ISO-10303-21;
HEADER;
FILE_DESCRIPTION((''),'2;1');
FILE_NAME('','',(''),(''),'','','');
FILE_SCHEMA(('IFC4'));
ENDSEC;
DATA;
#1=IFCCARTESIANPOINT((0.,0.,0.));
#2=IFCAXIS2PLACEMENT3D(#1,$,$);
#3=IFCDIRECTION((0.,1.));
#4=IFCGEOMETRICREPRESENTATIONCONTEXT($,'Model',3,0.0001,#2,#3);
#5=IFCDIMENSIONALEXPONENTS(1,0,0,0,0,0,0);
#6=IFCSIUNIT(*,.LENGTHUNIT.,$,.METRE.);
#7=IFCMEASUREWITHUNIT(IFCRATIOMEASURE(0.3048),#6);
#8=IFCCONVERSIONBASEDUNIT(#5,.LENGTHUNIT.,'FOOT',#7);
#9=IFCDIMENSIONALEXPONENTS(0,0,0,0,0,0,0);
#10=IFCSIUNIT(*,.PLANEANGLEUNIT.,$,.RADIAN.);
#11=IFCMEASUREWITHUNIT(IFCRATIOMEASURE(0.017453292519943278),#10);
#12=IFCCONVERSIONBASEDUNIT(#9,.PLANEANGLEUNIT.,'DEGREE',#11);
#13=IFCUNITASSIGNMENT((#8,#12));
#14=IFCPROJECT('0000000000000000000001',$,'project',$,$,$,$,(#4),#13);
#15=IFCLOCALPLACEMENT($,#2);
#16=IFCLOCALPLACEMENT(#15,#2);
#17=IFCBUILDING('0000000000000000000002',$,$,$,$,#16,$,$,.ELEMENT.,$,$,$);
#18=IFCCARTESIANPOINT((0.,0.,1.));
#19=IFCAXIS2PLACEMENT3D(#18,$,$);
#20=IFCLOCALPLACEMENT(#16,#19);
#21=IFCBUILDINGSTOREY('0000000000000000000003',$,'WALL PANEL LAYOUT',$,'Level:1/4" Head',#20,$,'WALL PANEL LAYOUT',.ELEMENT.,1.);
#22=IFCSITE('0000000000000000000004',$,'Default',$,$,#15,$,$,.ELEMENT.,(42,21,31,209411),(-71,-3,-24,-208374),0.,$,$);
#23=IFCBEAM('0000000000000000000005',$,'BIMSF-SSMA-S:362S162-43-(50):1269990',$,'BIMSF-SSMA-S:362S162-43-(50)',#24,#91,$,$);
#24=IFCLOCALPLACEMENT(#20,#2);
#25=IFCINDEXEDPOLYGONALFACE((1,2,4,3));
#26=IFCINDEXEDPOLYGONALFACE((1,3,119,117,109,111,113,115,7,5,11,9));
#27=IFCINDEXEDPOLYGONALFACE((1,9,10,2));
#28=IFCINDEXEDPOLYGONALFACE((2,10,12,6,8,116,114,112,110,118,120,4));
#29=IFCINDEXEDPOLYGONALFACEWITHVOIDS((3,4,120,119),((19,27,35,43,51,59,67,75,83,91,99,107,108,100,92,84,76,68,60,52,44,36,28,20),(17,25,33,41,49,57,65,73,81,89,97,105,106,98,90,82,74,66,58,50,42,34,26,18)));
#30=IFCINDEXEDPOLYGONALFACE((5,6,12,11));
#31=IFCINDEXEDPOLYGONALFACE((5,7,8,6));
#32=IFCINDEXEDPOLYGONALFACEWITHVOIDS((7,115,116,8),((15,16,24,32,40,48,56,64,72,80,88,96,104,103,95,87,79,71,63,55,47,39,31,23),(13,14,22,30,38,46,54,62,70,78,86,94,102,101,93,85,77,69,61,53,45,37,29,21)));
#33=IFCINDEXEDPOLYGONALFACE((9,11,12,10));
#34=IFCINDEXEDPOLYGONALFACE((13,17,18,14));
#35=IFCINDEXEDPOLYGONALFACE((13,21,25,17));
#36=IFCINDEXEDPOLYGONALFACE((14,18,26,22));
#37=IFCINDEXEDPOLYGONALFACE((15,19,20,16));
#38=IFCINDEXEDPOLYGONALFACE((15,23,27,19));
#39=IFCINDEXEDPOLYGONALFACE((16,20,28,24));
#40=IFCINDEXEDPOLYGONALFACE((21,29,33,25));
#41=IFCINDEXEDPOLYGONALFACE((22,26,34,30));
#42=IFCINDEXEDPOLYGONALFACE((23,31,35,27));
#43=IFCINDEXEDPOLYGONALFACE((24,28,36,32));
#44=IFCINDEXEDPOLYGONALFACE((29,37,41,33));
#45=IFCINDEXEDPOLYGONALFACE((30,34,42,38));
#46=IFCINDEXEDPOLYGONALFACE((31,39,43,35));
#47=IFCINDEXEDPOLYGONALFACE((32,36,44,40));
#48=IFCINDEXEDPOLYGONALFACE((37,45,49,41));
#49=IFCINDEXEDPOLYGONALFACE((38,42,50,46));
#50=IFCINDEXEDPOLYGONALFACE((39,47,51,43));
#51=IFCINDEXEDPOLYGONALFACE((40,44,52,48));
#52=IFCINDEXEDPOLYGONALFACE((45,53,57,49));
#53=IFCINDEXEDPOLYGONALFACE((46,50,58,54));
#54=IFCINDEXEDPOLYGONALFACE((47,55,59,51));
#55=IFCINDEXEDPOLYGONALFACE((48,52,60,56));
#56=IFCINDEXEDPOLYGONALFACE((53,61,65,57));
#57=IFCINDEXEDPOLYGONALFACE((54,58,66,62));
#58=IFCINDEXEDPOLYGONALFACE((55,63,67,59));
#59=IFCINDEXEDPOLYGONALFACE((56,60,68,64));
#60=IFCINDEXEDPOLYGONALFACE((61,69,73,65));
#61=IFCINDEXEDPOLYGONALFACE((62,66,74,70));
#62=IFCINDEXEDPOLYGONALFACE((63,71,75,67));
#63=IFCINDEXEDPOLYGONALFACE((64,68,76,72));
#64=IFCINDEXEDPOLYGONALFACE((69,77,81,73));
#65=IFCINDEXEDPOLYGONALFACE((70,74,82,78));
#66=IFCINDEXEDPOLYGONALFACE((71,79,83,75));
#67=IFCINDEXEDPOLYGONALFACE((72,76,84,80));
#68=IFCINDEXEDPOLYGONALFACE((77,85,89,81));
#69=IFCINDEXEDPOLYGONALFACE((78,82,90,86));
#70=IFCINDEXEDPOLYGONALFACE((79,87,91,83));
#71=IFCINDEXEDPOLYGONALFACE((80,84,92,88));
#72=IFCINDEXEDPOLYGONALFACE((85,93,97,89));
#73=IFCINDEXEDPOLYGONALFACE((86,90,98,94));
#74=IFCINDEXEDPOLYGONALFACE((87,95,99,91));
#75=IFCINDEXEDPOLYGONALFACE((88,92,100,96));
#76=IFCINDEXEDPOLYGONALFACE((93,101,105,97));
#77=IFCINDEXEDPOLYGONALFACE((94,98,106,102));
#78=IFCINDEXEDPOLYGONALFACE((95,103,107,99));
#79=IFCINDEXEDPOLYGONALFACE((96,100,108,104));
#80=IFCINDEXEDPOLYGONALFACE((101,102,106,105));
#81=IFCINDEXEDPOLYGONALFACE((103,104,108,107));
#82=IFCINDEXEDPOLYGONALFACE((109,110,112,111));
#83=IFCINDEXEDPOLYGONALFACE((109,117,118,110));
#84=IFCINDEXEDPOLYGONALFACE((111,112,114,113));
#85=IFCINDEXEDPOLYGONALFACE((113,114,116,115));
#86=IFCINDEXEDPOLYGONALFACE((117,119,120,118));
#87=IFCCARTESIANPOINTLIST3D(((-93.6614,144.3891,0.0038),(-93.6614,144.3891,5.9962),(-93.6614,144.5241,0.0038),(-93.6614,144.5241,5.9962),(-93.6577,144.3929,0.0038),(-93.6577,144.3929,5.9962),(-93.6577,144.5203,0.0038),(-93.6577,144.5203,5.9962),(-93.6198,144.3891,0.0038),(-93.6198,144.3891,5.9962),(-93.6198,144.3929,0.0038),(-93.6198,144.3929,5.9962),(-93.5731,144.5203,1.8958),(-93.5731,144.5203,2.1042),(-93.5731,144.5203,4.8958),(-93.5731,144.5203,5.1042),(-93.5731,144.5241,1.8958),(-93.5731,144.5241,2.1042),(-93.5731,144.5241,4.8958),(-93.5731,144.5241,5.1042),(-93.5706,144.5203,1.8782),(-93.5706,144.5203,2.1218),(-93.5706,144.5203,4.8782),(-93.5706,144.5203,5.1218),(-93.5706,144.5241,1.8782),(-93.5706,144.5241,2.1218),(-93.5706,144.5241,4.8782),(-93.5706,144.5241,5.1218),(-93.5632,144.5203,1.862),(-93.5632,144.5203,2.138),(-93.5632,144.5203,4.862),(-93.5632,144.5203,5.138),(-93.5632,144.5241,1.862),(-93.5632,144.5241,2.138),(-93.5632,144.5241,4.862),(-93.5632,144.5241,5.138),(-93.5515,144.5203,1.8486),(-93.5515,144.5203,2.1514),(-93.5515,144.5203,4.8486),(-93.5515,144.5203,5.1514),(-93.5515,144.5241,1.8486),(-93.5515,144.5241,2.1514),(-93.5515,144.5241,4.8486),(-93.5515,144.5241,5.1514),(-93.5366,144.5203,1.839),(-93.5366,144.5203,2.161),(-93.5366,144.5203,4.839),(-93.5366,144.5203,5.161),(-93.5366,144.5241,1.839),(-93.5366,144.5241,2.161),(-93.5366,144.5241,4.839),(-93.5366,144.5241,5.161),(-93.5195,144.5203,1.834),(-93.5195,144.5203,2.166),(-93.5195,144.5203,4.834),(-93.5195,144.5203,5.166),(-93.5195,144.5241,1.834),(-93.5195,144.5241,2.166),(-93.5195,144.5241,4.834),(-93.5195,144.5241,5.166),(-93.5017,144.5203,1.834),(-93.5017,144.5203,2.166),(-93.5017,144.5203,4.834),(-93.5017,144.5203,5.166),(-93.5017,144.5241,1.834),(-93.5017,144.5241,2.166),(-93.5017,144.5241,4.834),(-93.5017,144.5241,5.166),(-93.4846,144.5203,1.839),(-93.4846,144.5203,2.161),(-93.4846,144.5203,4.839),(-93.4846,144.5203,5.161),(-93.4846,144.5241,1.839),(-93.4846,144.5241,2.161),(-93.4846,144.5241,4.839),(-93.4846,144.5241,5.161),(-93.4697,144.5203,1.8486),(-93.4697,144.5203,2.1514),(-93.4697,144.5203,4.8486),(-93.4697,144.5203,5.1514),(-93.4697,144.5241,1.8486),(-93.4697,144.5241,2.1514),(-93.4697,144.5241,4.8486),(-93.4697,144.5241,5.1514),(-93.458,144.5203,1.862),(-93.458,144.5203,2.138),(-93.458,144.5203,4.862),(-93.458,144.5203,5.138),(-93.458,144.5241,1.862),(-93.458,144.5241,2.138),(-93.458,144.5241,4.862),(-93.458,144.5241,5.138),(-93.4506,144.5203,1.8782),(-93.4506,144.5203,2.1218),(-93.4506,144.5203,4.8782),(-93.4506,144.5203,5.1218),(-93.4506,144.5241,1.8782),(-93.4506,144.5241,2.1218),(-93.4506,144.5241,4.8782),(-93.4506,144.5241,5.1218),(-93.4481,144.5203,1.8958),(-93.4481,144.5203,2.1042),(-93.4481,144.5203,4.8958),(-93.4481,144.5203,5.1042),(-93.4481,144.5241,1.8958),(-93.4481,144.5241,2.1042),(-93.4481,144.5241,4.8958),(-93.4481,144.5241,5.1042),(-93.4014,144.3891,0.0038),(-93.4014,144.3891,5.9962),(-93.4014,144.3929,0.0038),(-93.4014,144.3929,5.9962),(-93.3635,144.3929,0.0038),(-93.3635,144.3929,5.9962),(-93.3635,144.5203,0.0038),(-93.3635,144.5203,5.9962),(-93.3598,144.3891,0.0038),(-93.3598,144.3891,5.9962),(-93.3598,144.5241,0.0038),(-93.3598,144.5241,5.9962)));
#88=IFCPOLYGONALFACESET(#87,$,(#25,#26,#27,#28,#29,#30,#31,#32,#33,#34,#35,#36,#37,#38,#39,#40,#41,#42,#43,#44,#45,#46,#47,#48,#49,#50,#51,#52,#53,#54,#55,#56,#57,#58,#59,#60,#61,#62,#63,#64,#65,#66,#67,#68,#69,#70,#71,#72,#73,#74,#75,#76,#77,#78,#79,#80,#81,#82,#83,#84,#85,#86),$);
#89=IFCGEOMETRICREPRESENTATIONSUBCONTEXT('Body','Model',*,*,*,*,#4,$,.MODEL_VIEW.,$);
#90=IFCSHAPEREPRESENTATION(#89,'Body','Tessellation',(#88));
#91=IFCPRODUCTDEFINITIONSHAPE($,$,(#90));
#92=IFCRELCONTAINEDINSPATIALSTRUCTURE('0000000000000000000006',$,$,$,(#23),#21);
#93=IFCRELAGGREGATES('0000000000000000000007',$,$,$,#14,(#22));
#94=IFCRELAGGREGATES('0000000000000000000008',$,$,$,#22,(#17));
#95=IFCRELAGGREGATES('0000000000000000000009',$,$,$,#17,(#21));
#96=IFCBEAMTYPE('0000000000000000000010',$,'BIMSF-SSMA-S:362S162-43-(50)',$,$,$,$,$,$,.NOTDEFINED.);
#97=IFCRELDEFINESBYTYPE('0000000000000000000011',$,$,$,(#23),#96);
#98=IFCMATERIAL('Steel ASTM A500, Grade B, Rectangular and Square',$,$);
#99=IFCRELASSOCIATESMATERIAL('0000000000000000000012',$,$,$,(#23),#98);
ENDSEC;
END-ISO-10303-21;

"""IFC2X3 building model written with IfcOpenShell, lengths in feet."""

from ifc_helpers import new_model, entity, si_unit, converted_unit, direction, frame, frame_2d, origin, place, context, subcontext, project, spatial, polyline, circle_curve, parameter, trimmed, segment, composite_curve, outline, extrude, boolean, material, type_object, element, save


model = new_model("IFC2X3")

# Units and contexts
model_context = context("Model", 3, precision=0.0001, world=origin(), true_north=direction((0.0, 1.0)))
body_context = subcontext(model_context, "Body", "Model", "MODEL_VIEW")
ifc_project = project(units=[converted_unit("LENGTHUNIT", "FOOT", entity("IfcRatioMeasure", 0.3048), si_unit("LENGTHUNIT", "METRE"), dimensions=[1, 0, 0, 0, 0, 0, 0]), converted_unit("PLANEANGLEUNIT", "DEGREE", entity("IfcRatioMeasure", 0.017453292519943278), si_unit("PLANEANGLEUNIT", "RADIAN"), dimensions=[0, 0, 0, 0, 0, 0, 0])], contexts=[model_context])

# Site, building, storey
site_placement = place(None, origin())
site = spatial("IfcSite", under=ifc_project, at=site_placement, Name="Default", CompositionType="ELEMENT", RefLatitude=(42, 21, 31, 209411), RefLongitude=(-71, -3, -24, -208374), RefElevation=0.0)
building_placement = place(site_placement, origin())
building = spatial("IfcBuilding", under=site, at=building_placement, CompositionType="ELEMENT")
storey_placement = place(building_placement, frame((0.0, 0.0, 1.0)))
storey = spatial("IfcBuildingStorey", under=building, at=storey_placement, Name="WALL PANEL LAYOUT", ObjectType="Level:1/4\" Head", LongName="WALL PANEL LAYOUT", CompositionType="ELEMENT", Elevation=1.0)

# Beam
ifc_material = material(Name="Steel ASTM A500, Grade B, Rectangular and Square")
beam_type_1 = type_object("IfcBeamType", Name="BIMSF-SSMA-S:362S162-43-(50)", PredefinedType="NOTDEFINED")
beam_1_placement = place(storey_placement, frame((-93.5106, 144.4566, 0.0038), z_axis=(1.0, 0.0, 0.0), x_axis=(0.0, 0.0, 1.0)))
element("IfcBeam", 1, at=beam_1_placement, inside=storey, type_object=beam_type_1, material=ifc_material, Name="BIMSF-SSMA-S:362S162-43-(50):1269990", ObjectType="BIMSF-SSMA-S:362S162-43-(50)", context=body_context, shape_type="SweptSolid", body=[
    boolean("DIFFERENCE", boolean("DIFFERENCE", extrude(outline(polyline([(-0.0894, -0.1508), (0.0456, -0.1508), (0.0456, -0.1092), (0.0419, -0.1092), (0.0419, -0.1471), (-0.0856, -0.1471), (-0.0856, 0.1471), (0.0419, 0.1471), (0.0419, 0.1092), (0.0456, 0.1092), (0.0456, 0.1508), (-0.0894, 0.1508), (-0.0894, -0.1508)])), frame((0.0, 0.0219, 0.0), z_axis=(1.0, 0.0, 0.0), x_axis=(0.0, 1.0, 0.0)), (0.0, 0.0, 1.0), 5.9925), extrude(outline(composite_curve([segment(trimmed(circle_curve(frame_2d((0.1042, 0.0), x_axis=(1.0, 0.0)), 0.0625), [parameter(270.0)], [parameter(90.0)], True, "PARAMETER"), True, "CONTINUOUS"), segment(polyline([(0.1042, 0.0625), (-0.1042, 0.0625)]), True, "CONTINUOUS"), segment(trimmed(circle_curve(frame_2d((-0.1042, 0.0), x_axis=(1.0, 0.0)), 0.0625), [parameter(90.0)], [parameter(270.0)], True, "PARAMETER"), True, "CONTINUOUS"), segment(polyline([(-0.1042, -0.0625), (0.1042, -0.0625)]), True, "CONTINUOUS")], self_intersect=False)), frame((4.9962, -0.0675, 0.0), z_axis=(0.0, 1.0, 0.0), x_axis=(1.0, 0.0, 0.0)), (0.0, 0.0, 1.0), 0.0038)), extrude(outline(composite_curve([segment(trimmed(circle_curve(frame_2d((0.1042, 0.0), x_axis=(1.0, 0.0)), 0.0625), [parameter(270.0)], [parameter(90.0)], True, "PARAMETER"), True, "CONTINUOUS"), segment(polyline([(0.1042, 0.0625), (-0.1042, 0.0625)]), True, "CONTINUOUS"), segment(trimmed(circle_curve(frame_2d((-0.1042, 0.0), x_axis=(1.0, 0.0)), 0.0625), [parameter(90.0)], [parameter(270.0)], True, "PARAMETER"), True, "CONTINUOUS"), segment(polyline([(-0.1042, -0.0625), (0.1042, -0.0625)]), True, "CONTINUOUS")], self_intersect=False)), frame((1.9962, -0.0675, 0.0), z_axis=(0.0, 1.0, 0.0), x_axis=(1.0, 0.0, 0.0)), (0.0, 0.0, 1.0), 0.0038)),
])

save(model, "model.ifc")
